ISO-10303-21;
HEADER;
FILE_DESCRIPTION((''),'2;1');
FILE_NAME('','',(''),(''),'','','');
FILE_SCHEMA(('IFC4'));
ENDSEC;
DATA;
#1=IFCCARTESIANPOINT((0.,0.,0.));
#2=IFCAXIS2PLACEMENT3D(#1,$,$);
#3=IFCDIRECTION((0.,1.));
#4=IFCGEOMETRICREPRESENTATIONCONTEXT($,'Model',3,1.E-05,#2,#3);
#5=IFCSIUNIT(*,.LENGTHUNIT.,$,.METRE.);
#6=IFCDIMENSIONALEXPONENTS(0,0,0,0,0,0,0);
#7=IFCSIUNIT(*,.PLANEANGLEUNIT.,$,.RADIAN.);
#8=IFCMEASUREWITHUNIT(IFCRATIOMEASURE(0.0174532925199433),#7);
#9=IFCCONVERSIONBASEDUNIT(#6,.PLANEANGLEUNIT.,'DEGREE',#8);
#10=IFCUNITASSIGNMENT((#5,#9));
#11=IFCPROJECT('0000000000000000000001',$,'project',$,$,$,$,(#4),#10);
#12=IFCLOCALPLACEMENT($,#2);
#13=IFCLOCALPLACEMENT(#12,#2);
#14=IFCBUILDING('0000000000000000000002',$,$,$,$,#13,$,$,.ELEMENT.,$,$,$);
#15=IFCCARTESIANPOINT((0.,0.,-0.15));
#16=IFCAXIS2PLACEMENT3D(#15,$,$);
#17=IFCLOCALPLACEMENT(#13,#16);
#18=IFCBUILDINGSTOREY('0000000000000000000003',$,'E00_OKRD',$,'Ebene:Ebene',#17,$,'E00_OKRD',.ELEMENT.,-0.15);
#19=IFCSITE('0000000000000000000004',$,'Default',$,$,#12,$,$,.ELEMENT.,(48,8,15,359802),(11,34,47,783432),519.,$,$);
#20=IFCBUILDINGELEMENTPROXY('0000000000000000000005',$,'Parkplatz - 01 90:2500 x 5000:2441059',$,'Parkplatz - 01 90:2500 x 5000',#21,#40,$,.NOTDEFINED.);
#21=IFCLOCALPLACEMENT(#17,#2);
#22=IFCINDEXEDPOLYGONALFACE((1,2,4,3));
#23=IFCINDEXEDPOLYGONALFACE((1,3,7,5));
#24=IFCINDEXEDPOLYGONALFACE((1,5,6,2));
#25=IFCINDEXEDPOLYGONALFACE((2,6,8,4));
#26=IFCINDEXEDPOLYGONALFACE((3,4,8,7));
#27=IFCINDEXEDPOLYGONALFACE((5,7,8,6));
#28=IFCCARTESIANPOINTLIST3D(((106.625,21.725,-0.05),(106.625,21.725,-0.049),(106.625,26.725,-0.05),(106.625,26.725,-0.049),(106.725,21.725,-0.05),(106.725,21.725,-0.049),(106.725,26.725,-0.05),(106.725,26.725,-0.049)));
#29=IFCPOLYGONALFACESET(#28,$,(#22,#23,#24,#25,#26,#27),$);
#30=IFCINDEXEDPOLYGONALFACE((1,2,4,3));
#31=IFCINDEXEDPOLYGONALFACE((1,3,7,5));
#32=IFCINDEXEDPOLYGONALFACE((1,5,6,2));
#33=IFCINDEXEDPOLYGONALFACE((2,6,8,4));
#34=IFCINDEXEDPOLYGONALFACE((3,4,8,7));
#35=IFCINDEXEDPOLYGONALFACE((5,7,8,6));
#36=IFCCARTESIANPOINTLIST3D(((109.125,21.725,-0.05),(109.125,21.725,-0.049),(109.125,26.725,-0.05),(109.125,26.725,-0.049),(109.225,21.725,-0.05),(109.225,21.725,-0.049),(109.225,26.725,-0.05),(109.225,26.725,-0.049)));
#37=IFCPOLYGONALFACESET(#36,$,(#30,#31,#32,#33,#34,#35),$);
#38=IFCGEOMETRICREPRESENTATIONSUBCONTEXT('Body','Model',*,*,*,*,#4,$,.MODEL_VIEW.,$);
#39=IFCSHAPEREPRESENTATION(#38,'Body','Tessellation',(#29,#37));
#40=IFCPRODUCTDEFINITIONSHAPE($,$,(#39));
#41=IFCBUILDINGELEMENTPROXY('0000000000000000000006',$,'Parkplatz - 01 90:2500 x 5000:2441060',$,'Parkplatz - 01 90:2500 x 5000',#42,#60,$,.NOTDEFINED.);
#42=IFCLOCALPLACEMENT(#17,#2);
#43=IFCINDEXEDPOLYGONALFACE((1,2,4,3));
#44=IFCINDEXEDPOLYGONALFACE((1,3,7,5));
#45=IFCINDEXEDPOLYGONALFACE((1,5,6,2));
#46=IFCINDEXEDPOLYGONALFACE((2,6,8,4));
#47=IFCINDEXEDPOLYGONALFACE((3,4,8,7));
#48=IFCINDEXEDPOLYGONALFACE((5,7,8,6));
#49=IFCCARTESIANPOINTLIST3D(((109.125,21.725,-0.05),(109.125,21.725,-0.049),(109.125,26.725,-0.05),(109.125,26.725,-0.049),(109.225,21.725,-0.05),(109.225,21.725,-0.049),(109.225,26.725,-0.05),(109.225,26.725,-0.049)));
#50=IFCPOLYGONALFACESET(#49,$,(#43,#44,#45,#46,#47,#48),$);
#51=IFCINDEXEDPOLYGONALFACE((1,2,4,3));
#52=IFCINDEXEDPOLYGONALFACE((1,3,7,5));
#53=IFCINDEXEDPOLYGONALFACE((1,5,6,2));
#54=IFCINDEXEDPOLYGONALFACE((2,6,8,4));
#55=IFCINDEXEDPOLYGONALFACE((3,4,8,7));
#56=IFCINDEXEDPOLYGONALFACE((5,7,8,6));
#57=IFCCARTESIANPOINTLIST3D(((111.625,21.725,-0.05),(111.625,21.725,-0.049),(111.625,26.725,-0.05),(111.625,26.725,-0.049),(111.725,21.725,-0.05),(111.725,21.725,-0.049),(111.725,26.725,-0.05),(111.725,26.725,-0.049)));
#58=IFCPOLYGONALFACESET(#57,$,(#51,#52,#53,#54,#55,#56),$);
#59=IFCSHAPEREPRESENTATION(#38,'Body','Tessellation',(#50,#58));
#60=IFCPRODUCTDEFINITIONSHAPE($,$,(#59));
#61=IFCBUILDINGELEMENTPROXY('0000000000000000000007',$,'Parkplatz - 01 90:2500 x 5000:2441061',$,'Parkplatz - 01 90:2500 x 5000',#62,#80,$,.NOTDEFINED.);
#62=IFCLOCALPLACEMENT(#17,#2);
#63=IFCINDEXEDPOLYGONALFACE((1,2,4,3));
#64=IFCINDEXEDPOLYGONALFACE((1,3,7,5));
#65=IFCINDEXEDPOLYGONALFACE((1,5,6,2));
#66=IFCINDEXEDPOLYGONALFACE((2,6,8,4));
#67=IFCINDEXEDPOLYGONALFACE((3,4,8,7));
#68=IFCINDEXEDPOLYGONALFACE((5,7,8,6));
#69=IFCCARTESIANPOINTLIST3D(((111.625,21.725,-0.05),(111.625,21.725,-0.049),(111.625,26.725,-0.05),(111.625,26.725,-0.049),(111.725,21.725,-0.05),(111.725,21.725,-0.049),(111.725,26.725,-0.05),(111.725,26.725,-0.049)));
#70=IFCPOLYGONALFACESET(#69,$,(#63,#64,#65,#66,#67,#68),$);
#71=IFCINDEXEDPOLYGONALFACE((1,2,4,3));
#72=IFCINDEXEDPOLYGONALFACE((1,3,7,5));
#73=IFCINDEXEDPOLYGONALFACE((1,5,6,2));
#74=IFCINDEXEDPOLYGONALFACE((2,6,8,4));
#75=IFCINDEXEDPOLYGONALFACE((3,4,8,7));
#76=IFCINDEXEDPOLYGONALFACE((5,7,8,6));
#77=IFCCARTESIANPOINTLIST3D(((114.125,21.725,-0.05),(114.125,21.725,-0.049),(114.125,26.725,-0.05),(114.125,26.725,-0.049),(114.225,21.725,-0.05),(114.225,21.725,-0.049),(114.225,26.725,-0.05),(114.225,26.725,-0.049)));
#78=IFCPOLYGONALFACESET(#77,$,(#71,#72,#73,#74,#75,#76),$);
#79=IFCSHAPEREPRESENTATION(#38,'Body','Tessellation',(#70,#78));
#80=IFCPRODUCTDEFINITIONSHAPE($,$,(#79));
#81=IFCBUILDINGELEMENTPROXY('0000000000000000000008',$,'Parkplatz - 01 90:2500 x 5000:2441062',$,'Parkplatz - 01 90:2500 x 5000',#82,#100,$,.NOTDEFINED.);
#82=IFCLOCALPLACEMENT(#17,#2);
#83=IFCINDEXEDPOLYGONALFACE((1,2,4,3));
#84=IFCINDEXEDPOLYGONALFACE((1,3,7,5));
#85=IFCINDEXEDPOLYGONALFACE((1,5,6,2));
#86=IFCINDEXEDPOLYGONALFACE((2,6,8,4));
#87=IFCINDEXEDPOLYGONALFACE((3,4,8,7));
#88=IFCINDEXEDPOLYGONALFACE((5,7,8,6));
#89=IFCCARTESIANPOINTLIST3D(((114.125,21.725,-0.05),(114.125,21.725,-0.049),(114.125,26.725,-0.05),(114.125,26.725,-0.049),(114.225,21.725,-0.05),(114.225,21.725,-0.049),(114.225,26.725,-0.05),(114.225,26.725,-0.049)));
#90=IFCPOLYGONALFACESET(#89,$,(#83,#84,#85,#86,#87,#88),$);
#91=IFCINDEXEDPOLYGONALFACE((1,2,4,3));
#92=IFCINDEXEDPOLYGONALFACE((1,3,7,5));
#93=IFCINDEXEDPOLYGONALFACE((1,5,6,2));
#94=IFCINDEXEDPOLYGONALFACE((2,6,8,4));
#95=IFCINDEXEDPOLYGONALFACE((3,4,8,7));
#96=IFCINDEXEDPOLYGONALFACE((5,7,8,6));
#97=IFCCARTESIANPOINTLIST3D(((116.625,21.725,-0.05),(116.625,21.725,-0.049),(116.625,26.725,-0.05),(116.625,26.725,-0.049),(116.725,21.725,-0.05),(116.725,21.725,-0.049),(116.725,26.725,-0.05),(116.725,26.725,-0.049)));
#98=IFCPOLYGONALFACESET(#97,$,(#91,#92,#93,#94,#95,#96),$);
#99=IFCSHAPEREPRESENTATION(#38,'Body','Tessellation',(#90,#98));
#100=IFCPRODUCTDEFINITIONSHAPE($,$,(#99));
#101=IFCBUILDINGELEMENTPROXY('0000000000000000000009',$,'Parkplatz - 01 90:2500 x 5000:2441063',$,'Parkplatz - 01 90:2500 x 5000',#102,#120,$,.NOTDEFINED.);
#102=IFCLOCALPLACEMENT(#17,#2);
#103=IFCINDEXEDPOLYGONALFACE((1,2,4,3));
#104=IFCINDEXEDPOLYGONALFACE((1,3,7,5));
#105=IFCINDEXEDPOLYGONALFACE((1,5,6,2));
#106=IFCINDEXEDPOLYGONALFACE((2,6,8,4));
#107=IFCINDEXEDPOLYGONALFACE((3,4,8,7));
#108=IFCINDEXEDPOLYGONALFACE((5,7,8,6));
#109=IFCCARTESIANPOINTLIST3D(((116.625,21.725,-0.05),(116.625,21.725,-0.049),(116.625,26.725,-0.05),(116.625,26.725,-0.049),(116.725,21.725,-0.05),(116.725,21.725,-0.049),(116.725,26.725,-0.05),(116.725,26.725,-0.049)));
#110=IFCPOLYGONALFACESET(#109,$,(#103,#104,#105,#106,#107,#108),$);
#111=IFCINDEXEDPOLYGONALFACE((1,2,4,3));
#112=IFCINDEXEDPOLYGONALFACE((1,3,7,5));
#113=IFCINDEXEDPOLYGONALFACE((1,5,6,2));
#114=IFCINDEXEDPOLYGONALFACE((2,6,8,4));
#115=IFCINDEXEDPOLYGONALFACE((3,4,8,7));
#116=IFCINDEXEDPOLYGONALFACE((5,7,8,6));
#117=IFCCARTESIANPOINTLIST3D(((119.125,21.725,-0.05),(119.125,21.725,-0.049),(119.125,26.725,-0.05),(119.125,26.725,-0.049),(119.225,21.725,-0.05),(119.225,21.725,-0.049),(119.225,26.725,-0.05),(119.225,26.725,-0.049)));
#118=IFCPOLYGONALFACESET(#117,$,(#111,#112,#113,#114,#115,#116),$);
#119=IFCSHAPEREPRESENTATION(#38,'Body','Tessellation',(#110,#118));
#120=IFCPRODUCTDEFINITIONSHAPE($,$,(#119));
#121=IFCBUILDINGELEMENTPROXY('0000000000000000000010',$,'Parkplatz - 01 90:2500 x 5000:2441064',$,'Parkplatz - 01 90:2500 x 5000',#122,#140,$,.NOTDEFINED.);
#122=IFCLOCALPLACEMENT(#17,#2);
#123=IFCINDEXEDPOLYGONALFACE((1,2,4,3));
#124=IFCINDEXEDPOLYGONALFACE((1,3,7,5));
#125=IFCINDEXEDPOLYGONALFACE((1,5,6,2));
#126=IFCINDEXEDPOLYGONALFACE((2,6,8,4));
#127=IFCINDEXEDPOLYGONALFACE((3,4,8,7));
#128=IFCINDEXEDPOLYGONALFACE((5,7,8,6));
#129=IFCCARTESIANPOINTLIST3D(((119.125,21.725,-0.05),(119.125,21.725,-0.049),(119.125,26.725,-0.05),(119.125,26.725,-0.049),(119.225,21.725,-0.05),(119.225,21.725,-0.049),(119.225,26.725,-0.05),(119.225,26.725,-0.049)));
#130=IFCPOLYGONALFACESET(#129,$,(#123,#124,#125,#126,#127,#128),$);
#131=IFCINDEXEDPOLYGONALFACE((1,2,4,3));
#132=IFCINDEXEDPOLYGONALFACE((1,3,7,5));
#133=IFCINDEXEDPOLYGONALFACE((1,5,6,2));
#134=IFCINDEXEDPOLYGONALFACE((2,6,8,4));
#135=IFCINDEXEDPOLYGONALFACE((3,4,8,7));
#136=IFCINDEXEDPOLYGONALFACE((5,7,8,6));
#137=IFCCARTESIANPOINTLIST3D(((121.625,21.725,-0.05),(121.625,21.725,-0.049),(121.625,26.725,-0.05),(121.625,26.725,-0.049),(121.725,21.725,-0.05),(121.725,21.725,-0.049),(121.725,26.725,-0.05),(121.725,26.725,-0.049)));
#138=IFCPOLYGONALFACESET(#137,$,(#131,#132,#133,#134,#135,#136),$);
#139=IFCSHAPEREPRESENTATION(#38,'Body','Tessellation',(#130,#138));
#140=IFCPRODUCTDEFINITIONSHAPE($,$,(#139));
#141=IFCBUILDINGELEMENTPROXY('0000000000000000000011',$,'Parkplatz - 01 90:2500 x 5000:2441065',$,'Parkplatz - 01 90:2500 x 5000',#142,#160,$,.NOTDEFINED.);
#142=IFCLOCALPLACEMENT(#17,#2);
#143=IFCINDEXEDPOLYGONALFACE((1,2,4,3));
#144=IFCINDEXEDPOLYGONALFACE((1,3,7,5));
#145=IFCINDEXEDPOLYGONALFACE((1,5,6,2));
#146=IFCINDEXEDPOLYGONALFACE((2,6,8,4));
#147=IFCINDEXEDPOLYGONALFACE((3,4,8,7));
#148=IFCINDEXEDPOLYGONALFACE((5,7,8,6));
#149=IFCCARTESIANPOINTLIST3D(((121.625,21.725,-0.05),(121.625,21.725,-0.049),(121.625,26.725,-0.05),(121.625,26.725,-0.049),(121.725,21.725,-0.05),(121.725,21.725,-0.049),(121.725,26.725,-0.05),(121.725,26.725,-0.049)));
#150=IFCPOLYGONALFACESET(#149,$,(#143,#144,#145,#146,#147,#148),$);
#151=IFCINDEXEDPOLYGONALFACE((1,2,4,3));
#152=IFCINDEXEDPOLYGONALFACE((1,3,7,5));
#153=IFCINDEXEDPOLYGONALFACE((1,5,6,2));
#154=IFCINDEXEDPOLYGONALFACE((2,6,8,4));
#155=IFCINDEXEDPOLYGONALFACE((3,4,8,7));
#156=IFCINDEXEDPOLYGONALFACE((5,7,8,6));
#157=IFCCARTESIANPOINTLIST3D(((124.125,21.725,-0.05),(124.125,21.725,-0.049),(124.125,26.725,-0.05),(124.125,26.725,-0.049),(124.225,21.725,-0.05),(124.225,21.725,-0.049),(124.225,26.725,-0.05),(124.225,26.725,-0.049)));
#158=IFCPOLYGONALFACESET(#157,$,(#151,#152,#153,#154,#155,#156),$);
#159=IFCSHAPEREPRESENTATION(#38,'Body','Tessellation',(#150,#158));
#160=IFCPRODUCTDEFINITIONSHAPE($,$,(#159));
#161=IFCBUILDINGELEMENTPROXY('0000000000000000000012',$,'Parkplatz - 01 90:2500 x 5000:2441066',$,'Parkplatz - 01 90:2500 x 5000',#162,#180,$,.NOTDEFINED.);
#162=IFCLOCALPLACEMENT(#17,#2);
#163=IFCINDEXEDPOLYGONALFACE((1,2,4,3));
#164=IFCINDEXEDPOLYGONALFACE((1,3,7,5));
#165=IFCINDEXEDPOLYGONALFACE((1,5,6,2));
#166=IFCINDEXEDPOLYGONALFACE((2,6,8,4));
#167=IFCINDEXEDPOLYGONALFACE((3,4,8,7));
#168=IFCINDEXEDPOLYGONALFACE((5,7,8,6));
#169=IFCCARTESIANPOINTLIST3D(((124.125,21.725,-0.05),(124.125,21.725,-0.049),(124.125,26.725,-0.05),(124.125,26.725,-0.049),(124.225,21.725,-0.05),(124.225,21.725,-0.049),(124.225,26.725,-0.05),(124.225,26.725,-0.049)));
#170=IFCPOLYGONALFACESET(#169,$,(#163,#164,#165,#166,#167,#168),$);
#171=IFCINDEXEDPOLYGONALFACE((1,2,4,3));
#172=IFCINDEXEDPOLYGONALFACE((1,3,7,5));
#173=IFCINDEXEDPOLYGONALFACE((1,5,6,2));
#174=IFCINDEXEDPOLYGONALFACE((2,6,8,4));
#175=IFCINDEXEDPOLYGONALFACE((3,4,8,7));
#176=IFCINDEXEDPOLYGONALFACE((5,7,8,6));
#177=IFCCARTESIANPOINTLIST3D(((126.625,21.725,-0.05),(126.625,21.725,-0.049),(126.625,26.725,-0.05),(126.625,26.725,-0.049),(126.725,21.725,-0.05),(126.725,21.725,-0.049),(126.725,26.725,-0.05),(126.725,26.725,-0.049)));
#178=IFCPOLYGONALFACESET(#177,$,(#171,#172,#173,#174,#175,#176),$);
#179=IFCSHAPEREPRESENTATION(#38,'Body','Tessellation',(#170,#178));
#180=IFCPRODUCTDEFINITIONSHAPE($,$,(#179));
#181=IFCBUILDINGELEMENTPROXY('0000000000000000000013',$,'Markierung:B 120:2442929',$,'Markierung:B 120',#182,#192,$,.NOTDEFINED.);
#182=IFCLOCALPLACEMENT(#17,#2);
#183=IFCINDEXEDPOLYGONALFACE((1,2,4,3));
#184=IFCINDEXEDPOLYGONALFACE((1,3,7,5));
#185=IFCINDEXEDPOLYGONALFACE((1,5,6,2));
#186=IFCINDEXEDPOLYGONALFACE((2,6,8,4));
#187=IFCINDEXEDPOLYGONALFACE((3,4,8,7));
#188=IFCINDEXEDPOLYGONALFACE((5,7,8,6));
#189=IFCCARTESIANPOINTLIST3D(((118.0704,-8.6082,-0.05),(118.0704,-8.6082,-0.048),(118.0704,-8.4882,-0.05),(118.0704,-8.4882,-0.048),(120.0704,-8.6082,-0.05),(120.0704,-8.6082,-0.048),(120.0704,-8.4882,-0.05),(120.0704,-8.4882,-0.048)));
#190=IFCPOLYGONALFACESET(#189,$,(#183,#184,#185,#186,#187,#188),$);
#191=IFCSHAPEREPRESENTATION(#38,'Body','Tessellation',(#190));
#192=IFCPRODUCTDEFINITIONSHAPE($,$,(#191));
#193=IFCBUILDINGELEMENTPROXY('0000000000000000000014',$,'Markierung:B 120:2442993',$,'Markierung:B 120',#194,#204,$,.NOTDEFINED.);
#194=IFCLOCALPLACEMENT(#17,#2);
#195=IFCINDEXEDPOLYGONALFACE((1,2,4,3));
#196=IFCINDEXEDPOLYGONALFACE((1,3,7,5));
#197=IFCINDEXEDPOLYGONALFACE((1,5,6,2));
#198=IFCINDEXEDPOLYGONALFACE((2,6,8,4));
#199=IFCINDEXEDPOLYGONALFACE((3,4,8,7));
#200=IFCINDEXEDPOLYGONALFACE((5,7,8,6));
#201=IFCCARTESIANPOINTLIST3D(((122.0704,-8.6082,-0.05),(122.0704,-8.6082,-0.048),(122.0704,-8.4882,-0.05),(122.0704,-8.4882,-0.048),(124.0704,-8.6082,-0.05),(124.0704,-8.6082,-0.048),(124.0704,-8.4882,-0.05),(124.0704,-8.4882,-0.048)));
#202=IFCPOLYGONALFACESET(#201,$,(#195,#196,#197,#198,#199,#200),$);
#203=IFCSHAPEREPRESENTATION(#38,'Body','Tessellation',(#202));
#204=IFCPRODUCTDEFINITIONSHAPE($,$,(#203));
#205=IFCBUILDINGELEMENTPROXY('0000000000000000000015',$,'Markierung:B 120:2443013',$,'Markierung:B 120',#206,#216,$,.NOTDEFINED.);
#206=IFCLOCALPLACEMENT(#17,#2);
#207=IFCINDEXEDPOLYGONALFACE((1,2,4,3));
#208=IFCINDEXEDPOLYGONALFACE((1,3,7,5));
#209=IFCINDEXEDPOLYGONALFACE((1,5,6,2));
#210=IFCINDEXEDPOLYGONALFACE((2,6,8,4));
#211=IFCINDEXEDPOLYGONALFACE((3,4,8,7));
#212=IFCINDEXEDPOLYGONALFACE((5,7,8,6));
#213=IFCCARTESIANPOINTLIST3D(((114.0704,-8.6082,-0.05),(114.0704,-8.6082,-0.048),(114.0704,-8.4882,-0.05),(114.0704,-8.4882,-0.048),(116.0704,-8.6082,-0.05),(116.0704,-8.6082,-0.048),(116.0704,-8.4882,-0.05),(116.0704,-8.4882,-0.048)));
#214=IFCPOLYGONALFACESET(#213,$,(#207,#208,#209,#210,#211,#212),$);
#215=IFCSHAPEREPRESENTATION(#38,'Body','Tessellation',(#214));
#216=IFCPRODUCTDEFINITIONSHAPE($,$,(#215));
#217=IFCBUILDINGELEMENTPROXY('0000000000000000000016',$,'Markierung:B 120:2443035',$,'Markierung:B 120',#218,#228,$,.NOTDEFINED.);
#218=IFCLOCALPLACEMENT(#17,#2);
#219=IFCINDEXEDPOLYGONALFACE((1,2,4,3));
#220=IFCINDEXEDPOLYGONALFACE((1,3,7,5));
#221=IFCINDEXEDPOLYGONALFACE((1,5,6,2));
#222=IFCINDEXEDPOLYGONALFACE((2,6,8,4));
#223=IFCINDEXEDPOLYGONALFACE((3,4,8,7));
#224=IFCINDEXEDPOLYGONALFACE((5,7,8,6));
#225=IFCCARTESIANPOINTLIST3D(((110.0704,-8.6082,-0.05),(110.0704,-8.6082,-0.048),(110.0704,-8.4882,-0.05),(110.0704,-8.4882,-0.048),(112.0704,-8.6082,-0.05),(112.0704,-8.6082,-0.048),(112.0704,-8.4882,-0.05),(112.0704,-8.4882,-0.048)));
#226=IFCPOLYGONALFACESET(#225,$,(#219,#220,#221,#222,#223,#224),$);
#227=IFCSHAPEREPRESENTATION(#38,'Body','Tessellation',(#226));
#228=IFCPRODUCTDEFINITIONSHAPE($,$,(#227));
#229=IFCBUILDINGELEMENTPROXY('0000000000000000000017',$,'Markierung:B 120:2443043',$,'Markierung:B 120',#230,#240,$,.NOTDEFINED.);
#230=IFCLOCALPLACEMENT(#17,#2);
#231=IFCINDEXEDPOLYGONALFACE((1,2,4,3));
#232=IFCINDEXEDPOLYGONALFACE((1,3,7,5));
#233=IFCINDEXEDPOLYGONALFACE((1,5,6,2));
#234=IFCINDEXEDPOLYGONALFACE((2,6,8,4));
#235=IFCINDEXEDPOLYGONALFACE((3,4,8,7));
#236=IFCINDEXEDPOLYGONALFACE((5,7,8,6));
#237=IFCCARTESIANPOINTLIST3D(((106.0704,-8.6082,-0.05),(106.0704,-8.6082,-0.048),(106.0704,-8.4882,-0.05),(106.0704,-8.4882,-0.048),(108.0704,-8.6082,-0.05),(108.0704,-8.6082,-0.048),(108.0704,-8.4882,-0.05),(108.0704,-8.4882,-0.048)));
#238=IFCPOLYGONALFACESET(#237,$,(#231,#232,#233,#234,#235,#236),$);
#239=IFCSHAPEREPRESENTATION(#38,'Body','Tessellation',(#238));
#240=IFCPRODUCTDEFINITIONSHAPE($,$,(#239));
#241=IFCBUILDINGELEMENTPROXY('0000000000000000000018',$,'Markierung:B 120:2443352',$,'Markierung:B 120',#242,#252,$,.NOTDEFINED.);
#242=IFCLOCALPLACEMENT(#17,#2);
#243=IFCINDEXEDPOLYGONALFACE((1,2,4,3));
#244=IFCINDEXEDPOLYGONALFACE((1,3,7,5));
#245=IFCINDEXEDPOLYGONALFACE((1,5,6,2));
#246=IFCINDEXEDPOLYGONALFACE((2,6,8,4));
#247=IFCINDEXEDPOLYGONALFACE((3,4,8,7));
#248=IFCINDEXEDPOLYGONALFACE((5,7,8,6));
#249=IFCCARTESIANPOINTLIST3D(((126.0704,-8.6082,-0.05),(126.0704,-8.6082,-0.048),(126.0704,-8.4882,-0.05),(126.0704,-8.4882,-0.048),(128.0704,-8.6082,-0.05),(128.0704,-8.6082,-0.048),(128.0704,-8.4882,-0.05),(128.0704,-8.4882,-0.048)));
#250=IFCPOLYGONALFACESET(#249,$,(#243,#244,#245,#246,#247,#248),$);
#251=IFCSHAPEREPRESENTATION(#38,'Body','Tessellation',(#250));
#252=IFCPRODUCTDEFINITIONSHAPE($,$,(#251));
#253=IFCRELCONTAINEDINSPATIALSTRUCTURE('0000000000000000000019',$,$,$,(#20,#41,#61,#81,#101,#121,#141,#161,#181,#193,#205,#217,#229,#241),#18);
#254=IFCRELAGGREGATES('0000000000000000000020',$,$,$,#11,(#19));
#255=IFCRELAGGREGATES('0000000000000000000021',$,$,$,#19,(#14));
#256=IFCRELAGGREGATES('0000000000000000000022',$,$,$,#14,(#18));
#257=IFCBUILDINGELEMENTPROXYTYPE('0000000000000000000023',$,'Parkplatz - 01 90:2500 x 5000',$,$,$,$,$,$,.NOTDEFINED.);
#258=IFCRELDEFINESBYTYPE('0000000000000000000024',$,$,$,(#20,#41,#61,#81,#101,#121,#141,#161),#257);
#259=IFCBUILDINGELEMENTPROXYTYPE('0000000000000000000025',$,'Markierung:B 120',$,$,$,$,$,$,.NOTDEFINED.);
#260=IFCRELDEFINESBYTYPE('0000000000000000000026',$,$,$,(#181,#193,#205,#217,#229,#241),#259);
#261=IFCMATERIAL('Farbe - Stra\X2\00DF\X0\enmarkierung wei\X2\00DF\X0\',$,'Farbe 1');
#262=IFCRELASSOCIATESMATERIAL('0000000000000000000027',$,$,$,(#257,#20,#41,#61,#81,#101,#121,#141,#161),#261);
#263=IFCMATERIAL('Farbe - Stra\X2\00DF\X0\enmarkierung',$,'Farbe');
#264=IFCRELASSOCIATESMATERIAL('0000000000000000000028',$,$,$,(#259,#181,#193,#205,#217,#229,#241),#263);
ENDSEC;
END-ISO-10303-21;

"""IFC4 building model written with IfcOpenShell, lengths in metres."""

from ifc_helpers import new_model, entity, si_unit, converted_unit, direction, frame, frame_2d, origin, origin_2d_with_axis, place, context, subcontext, project, spatial, rectangle, extrude, source, transform, mapped, material, type_object, type_shapes, element, save


model = new_model("IFC4")

# Units and contexts
model_context = context("Model", 3, precision=1e-05, world=origin(), true_north=direction((0.0, 1.0)))
body_context = subcontext(model_context, "Body", "Model", "MODEL_VIEW")
ifc_project = project(units=[si_unit("LENGTHUNIT", "METRE"), converted_unit("PLANEANGLEUNIT", "DEGREE", entity("IfcRatioMeasure", 0.0174532925199433), si_unit("PLANEANGLEUNIT", "RADIAN"), dimensions=[0, 0, 0, 0, 0, 0, 0])], contexts=[model_context])

# Site, building, storey
site_placement = place(None, frame((0.0, 0.0, 0.0)))
site = spatial("IfcSite", under=ifc_project, at=site_placement, Name="Default", CompositionType="ELEMENT", RefLatitude=(48, 8, 15, 359802), RefLongitude=(11, 34, 47, 783432), RefElevation=519.0)
building_placement = place(site_placement, origin())
building = spatial("IfcBuilding", under=site, at=building_placement, CompositionType="ELEMENT")
storey_placement = place(building_placement, frame((0.0, 0.0, -0.15)))
storey = spatial("IfcBuildingStorey", under=building, at=storey_placement, Name="E00_OKRD", ObjectType="Ebene:Ebene", LongName="E00_OKRD", CompositionType="ELEMENT", Elevation=-0.15)

# Building element proxies
ifc_material_1 = material(Name="Farbe - Straßenmarkierung weiß", Category="Farbe 1")
building_element_proxy_type_1 = type_object("IfcBuildingElementProxyType", Name="Parkplatz - 01 90:2500 x 5000", PredefinedType="NOTDEFINED", material=ifc_material_1)
shared_shape_1 = source(origin(), body_context, "Body", "SweptSolid", [
    extrude(rectangle(XDim=0.1, YDim=5.0, at=origin_2d_with_axis()), frame((2.5456, 2.5, 0.0)), (0.0, 0.0, 1.0), 0.001),
    extrude(rectangle(XDim=5.0, YDim=0.1, at=origin_2d_with_axis()), frame((0.0456, 2.5, 0.0), z_axis=(0.0, 0.0, 1.0), x_axis=(0.0, 1.0, 0.0)), (0.0, 0.0, 1.0), 0.001),
])
type_shapes(building_element_proxy_type_1, [shared_shape_1])
for number, where, z_axis, x_axis, name in (
    (1, (109.2206, 26.725, -0.05), (0.0, 0.0, 1.0), (-1.0, 0.0, 0.0), "Parkplatz - 01 90:2500 x 5000:2441059"),
    (2, (111.7206, 26.725, -0.05), (0.0, 0.0, 1.0), (-1.0, 0.0, 0.0), "Parkplatz - 01 90:2500 x 5000:2441060"),
    (3, (114.2206, 26.725, -0.05), (0.0, 0.0, 1.0), (-1.0, 0.0, 0.0), "Parkplatz - 01 90:2500 x 5000:2441061"),
    (4, (116.7206, 26.725, -0.05), (0.0, 0.0, 1.0), (-1.0, 0.0, 0.0), "Parkplatz - 01 90:2500 x 5000:2441062"),
    (5, (119.2206, 26.725, -0.05), (0.0, 0.0, 1.0), (-1.0, 0.0, 0.0), "Parkplatz - 01 90:2500 x 5000:2441063"),
    (6, (121.7206, 26.725, -0.05), (0.0, 0.0, 1.0), (-1.0, 0.0, 0.0), "Parkplatz - 01 90:2500 x 5000:2441064"),
    (7, (124.2206, 26.725, -0.05), (0.0, 0.0, 1.0), (-1.0, 0.0, 0.0), "Parkplatz - 01 90:2500 x 5000:2441065"),
    (8, (126.7206, 26.725, -0.05), (0.0, 0.0, 1.0), (-1.0, 0.0, 0.0), "Parkplatz - 01 90:2500 x 5000:2441066"),
):
    element("IfcBuildingElementProxy", number, at=place(storey_placement, frame(where, z_axis=z_axis, x_axis=x_axis)), inside=storey, type_object=building_element_proxy_type_1, material=ifc_material_1, Name=name, ObjectType="Parkplatz - 01 90:2500 x 5000", PredefinedType="NOTDEFINED", context=body_context, shape_type="MappedRepresentation", body=[
        mapped(shared_shape_1, transform((0.0, 0.0, 0.0), scale=1.0)),
    ])
ifc_material_2 = material(Name="Farbe - Straßenmarkierung", Category="Farbe")
building_element_proxy_type_2 = type_object("IfcBuildingElementProxyType", Name="Markierung:B 120", PredefinedType="NOTDEFINED", material=ifc_material_2)
shared_shape_2 = source(origin(), body_context, "Body", "SweptSolid", [
    extrude(rectangle(XDim=0.12, YDim=2.0, at=frame_2d((0.0, 0.0), x_axis=(1.0, 0.0))), frame((0.06, 1.0, 0.0), z_axis=(0.0, 0.0, 1.0), x_axis=(-1.0, 0.0, 0.0)), (0.0, 0.0, 1.0), 0.002),
])
type_shapes(building_element_proxy_type_2, [shared_shape_2])
for number, where, z_axis, x_axis, name in (
    (9, (120.0704, -8.6082, -0.05), (0.0, 0.0, 1.0), (0.0, 1.0, 0.0), "Markierung:B 120:2442929"),
    (10, (124.0704, -8.6082, -0.05), (0.0, 0.0, 1.0), (0.0, 1.0, 0.0), "Markierung:B 120:2442993"),
    (11, (116.0704, -8.6082, -0.05), (0.0, 0.0, 1.0), (0.0, 1.0, 0.0), "Markierung:B 120:2443013"),
    (12, (112.0704, -8.6082, -0.05), (0.0, 0.0, 1.0), (0.0, 1.0, 0.0), "Markierung:B 120:2443035"),
    (13, (108.0704, -8.6082, -0.05), (0.0, 0.0, 1.0), (0.0, 1.0, 0.0), "Markierung:B 120:2443043"),
    (14, (128.0704, -8.6082, -0.05), (0.0, 0.0, 1.0), (0.0, 1.0, 0.0), "Markierung:B 120:2443352"),
):
    element("IfcBuildingElementProxy", number, at=place(storey_placement, frame(where, z_axis=z_axis, x_axis=x_axis)), inside=storey, type_object=building_element_proxy_type_2, material=ifc_material_2, Name=name, ObjectType="Markierung:B 120", PredefinedType="NOTDEFINED", context=body_context, shape_type="MappedRepresentation", body=[
        mapped(shared_shape_2, transform((0.0, 0.0, 0.0), scale=1.0)),
    ])

save(model, "model.ifc")
